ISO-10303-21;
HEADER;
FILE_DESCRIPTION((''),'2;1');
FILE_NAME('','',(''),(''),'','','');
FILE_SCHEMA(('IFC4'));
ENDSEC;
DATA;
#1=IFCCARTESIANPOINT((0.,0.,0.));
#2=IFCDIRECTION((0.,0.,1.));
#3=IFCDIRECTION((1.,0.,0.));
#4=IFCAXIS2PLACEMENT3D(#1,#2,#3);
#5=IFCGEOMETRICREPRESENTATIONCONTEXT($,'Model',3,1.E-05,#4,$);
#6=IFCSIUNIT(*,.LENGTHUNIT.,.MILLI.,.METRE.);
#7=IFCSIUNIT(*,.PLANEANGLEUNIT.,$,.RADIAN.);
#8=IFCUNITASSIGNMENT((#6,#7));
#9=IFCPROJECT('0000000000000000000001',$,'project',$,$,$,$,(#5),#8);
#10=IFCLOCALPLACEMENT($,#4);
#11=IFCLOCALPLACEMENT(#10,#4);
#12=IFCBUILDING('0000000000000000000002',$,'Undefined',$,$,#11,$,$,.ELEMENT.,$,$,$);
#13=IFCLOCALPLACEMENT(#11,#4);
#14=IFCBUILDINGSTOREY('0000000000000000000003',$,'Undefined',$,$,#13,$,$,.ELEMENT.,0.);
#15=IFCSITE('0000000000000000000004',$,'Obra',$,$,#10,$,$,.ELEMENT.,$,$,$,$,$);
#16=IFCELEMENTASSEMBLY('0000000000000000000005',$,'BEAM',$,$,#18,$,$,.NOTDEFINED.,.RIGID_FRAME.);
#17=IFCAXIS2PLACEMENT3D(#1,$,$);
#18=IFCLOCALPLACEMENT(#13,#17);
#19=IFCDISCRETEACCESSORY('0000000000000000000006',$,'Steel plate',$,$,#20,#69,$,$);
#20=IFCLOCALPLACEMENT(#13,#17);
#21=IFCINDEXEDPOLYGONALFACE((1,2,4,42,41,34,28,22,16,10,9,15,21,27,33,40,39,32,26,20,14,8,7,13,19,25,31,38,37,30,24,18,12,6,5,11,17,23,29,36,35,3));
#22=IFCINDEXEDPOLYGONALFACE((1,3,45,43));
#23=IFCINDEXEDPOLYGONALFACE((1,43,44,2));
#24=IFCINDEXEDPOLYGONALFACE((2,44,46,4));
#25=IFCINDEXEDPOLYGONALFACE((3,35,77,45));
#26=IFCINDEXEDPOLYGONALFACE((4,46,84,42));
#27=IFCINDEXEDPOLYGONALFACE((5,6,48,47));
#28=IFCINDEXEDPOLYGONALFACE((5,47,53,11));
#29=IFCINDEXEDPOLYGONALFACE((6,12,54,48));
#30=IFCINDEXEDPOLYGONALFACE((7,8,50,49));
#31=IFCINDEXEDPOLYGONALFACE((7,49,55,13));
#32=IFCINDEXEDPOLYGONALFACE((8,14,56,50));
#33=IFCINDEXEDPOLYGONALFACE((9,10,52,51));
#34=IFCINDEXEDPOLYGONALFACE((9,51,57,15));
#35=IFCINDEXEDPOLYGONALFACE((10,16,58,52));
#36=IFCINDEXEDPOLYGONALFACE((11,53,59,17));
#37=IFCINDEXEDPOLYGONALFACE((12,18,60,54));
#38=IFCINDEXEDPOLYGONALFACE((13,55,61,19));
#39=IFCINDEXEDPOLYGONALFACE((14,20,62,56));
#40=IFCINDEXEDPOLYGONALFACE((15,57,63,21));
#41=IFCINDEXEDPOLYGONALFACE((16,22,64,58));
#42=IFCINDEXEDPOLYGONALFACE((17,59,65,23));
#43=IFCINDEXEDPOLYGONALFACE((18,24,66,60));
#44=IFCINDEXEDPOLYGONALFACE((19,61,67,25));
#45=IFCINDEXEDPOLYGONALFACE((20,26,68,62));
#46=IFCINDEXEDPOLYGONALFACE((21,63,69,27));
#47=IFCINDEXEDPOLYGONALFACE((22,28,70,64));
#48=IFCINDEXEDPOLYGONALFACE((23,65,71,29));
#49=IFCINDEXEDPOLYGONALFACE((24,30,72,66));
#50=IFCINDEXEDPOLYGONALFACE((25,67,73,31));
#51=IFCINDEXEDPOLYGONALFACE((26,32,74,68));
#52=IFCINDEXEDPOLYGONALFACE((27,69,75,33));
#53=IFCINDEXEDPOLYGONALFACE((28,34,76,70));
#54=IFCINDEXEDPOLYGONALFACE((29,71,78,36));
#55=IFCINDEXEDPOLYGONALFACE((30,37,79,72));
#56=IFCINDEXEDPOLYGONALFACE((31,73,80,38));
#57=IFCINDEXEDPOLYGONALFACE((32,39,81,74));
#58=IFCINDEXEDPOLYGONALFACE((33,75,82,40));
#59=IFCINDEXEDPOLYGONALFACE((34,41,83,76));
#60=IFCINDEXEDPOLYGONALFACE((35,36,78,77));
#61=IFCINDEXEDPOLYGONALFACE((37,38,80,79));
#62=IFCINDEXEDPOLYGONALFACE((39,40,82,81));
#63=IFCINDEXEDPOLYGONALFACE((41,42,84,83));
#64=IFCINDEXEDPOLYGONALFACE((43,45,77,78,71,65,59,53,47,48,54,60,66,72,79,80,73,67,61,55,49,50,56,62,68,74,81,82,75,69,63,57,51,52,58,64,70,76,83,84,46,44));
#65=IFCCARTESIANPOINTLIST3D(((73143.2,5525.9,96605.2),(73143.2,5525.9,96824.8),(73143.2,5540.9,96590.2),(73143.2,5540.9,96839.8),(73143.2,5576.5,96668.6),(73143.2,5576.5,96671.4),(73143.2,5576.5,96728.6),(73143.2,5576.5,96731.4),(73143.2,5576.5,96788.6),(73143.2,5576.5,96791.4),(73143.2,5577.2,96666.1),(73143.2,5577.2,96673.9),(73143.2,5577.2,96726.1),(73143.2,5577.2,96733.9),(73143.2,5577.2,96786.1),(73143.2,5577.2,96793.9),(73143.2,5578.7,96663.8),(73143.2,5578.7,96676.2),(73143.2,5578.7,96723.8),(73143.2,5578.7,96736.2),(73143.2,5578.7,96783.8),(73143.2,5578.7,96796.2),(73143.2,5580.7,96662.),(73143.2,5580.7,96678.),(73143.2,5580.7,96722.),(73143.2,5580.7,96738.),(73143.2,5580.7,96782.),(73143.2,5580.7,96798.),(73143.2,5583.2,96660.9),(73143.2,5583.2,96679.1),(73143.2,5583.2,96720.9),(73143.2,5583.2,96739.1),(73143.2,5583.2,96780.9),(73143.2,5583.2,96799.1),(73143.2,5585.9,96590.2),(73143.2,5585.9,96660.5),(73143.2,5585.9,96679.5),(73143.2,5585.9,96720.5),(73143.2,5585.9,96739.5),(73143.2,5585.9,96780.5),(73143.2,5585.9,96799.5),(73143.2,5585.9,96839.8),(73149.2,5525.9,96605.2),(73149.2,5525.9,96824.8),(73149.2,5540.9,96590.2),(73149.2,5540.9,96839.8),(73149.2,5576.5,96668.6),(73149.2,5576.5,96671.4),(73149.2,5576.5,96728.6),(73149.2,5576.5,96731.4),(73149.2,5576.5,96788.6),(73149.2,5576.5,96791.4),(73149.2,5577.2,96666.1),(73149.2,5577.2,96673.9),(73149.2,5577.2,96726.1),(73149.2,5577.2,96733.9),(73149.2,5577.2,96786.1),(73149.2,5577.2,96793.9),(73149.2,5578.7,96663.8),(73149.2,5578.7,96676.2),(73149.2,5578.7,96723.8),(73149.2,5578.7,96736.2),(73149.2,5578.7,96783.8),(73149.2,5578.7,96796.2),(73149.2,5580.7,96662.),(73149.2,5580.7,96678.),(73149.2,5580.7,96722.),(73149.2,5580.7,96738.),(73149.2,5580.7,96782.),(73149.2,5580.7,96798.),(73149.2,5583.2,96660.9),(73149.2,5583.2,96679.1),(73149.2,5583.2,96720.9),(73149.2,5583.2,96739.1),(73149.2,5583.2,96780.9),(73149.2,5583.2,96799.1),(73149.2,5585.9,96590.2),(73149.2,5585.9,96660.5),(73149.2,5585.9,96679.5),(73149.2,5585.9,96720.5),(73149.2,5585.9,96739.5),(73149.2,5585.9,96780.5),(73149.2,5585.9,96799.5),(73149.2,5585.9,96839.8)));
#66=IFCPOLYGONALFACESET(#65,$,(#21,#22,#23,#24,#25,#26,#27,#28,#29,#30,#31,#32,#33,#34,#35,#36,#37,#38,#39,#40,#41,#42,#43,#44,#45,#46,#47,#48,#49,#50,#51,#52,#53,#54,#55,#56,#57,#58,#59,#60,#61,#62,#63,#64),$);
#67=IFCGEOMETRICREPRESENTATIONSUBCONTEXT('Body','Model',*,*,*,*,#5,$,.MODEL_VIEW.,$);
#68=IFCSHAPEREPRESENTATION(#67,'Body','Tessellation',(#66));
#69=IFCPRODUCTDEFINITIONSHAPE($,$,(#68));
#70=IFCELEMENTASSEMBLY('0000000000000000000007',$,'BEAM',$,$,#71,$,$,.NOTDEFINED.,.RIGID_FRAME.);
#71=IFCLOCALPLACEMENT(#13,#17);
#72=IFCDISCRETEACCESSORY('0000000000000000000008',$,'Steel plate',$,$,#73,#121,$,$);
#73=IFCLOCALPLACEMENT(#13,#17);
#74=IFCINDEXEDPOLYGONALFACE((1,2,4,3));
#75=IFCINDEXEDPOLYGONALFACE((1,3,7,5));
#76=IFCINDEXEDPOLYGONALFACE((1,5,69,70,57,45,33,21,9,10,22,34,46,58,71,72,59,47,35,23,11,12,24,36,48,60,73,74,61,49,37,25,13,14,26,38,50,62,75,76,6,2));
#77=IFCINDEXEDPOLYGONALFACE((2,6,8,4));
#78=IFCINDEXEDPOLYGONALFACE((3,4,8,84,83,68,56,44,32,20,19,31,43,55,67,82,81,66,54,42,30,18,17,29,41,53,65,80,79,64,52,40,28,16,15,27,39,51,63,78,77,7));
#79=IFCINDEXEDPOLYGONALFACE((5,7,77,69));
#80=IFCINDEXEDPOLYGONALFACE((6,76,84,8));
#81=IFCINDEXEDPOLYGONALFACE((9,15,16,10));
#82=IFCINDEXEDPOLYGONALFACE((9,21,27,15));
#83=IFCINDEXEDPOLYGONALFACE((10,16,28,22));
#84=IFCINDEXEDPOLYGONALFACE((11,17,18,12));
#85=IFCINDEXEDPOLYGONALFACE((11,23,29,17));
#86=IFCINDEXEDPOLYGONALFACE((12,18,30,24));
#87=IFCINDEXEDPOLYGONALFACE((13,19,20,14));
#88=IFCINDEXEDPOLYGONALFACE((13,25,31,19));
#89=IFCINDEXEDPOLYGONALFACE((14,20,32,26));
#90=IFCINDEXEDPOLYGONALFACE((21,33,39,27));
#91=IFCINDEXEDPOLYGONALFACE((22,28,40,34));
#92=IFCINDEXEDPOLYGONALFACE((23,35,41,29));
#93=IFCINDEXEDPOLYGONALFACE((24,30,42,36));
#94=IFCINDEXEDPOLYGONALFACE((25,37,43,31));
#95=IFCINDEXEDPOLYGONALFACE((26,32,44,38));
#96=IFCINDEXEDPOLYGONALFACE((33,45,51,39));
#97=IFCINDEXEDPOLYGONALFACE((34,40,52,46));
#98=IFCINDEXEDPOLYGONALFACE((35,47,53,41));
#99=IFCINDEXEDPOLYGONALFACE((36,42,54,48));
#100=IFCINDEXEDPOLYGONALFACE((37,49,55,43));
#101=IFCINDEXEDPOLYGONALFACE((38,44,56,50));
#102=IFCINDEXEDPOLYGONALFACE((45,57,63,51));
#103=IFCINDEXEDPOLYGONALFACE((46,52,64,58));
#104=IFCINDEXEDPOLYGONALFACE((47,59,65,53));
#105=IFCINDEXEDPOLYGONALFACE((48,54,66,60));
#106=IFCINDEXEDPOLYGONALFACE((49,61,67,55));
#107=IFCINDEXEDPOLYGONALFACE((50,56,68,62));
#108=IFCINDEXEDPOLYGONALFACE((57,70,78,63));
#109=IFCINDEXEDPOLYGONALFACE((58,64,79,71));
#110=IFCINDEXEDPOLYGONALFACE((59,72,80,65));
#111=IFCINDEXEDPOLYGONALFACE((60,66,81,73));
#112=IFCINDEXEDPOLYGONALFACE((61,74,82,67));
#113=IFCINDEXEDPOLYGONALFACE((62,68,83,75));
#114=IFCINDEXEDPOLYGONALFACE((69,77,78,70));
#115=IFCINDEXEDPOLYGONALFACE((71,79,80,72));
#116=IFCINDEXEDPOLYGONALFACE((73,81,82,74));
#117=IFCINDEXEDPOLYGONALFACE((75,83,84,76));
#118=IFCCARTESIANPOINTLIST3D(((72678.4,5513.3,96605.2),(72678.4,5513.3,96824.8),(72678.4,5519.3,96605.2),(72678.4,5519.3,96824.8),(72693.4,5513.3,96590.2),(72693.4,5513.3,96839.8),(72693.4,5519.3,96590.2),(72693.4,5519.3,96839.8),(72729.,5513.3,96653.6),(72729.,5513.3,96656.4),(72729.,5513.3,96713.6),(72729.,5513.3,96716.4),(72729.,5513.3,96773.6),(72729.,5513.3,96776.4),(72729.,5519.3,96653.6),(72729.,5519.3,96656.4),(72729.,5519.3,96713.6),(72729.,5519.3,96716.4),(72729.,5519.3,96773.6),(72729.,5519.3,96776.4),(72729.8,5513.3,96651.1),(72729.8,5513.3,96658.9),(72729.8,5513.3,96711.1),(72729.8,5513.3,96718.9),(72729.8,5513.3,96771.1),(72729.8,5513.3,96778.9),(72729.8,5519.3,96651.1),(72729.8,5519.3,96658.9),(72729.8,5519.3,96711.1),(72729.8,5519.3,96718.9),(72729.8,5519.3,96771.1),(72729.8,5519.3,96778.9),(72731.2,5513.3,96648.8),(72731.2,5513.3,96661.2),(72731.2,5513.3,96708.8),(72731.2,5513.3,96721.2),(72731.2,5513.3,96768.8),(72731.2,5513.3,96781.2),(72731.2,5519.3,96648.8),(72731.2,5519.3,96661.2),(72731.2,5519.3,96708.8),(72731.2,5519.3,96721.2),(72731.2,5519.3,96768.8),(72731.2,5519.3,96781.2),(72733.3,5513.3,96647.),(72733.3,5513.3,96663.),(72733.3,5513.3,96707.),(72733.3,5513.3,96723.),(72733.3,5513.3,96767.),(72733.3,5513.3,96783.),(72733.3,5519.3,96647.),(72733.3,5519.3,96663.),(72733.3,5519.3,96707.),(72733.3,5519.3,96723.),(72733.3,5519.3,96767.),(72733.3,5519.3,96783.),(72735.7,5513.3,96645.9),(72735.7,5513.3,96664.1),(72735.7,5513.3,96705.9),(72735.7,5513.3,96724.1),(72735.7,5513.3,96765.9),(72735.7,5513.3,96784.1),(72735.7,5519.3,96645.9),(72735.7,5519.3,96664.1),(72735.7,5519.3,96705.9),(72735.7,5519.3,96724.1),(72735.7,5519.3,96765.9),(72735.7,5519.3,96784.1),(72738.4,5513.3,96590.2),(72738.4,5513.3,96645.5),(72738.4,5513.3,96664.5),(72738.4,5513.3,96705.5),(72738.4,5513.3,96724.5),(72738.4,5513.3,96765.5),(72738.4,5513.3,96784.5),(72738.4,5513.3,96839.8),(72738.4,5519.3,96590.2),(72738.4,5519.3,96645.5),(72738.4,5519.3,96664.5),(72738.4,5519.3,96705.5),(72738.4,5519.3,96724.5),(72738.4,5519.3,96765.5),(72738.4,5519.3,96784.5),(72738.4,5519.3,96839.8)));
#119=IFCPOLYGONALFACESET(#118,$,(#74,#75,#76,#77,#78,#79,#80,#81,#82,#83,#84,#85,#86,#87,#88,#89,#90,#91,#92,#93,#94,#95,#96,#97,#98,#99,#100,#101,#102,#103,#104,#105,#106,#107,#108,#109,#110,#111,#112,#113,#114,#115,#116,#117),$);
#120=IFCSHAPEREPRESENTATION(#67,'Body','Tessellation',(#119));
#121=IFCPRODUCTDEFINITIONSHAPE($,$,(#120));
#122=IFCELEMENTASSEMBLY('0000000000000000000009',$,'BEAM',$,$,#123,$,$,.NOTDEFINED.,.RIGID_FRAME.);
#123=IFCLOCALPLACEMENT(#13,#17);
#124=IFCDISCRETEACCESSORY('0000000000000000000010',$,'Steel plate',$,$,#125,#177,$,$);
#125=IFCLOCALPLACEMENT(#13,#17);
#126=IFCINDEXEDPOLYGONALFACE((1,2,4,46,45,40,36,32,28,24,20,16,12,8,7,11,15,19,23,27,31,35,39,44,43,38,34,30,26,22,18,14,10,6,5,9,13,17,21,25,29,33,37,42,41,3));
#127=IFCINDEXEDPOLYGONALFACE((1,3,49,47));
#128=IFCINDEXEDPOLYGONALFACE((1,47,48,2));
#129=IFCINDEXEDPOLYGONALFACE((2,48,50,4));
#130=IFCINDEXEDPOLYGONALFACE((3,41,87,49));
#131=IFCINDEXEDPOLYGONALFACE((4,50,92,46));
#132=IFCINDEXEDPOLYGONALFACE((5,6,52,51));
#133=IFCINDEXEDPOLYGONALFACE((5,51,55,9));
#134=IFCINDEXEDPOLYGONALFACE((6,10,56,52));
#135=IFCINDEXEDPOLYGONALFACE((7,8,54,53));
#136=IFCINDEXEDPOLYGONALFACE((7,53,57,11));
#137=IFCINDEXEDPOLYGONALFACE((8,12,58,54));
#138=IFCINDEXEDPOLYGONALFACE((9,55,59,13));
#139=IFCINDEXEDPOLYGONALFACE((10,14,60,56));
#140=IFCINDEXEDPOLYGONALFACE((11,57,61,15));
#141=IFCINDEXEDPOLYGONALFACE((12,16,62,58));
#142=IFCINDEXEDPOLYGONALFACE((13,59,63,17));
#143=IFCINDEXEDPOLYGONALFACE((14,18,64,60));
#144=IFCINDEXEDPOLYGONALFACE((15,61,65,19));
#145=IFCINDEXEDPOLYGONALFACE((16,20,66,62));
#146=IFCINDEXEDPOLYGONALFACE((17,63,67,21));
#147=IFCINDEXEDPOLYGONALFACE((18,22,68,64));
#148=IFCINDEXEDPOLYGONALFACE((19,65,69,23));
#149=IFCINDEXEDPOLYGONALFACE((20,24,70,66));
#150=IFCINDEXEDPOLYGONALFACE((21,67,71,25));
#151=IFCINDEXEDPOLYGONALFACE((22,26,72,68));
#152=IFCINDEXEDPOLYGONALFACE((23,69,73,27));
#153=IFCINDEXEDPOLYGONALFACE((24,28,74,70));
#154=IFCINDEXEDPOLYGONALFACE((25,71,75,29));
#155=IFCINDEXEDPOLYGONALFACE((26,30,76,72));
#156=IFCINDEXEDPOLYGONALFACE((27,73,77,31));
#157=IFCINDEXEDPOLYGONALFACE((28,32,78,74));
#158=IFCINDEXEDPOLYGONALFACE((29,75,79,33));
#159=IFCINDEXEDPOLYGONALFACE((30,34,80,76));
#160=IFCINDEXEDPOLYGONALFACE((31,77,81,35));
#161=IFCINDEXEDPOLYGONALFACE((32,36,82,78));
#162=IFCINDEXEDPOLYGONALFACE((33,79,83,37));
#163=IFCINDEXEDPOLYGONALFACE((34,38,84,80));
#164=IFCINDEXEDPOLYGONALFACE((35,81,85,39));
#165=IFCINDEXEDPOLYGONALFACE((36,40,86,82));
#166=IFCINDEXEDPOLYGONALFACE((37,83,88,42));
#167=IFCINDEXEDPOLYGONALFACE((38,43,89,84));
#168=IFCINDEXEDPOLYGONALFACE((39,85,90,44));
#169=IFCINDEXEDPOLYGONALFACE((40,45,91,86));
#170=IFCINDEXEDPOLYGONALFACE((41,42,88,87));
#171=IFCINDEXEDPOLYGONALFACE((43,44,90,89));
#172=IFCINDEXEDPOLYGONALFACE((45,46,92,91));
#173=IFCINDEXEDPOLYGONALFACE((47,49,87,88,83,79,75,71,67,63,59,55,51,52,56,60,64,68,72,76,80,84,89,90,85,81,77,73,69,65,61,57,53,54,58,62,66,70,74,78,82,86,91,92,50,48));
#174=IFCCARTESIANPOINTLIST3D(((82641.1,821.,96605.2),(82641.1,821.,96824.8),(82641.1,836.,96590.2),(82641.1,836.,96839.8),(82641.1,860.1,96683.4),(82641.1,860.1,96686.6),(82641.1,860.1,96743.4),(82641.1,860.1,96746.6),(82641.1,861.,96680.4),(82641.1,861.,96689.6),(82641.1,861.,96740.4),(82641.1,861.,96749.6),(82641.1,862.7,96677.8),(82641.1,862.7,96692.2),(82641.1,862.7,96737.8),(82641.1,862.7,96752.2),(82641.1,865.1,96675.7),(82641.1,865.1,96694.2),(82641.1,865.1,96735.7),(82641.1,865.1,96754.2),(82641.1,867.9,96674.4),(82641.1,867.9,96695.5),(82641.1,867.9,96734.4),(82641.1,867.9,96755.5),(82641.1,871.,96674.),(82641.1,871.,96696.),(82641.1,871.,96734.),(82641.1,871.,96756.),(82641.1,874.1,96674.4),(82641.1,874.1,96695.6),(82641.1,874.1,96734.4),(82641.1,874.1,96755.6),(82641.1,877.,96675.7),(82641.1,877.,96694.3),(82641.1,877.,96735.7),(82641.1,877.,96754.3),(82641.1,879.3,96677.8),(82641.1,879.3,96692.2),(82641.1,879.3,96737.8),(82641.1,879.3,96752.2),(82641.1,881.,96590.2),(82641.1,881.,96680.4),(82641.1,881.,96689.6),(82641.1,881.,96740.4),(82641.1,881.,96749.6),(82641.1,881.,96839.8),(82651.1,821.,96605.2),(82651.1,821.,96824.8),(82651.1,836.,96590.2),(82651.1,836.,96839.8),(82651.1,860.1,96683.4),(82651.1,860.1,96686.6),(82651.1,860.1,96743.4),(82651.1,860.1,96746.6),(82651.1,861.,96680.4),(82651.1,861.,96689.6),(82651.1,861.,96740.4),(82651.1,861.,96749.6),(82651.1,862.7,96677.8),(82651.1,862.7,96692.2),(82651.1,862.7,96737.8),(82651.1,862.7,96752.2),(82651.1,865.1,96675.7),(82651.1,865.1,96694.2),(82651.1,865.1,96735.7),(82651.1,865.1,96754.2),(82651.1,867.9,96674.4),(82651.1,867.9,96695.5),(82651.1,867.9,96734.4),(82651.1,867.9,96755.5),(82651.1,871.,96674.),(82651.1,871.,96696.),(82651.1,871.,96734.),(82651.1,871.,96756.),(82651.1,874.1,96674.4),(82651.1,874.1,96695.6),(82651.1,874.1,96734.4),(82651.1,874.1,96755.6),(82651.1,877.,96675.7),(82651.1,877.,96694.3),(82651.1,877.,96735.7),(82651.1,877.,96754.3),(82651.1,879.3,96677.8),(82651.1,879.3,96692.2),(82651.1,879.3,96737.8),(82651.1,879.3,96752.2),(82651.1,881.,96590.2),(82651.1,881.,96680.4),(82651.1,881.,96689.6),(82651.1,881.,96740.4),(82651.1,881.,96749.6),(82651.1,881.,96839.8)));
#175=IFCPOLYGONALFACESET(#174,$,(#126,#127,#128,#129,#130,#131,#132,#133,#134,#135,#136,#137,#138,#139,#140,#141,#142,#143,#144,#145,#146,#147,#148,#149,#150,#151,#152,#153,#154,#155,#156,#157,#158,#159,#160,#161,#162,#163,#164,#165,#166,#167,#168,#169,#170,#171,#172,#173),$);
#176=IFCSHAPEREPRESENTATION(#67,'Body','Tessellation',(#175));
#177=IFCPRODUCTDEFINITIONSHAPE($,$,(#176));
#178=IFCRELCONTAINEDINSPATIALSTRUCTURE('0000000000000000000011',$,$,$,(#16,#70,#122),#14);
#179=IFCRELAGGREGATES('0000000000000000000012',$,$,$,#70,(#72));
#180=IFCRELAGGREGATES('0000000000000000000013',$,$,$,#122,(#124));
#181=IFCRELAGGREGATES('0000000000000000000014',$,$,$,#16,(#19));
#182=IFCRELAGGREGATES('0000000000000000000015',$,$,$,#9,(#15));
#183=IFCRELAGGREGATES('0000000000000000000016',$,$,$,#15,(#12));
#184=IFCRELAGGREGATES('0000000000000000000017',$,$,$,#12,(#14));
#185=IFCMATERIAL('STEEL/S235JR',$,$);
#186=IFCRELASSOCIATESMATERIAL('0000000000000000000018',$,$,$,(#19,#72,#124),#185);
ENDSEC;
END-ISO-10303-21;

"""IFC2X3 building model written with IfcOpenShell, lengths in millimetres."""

from ifc_helpers import new_model, si_unit, frame, origin_with_axes, origin_2d_with_axis, place, context, subcontext, project, spatial, polyline, circle, outline, extrude, source, transform, mapped, material, element, aggregate, save


model = new_model("IFC2X3")

# Units and contexts
model_context = context("Model", 3, precision=1e-05, world=origin_with_axes())
body_context = subcontext(model_context, "Body", "Model", "MODEL_VIEW")
ifc_project = project(units=[si_unit("LENGTHUNIT", "METRE", prefix="MILLI"), si_unit("PLANEANGLEUNIT", "RADIAN")], contexts=[model_context])

# Site, building, storey
site_placement = place(None, origin_with_axes())
site = spatial("IfcSite", under=ifc_project, at=site_placement, Name="Obra", CompositionType="ELEMENT")
building_placement = place(site_placement, origin_with_axes())
building = spatial("IfcBuilding", under=site, at=building_placement, Name="Undefined", CompositionType="ELEMENT")
storey_placement = place(building_placement, origin_with_axes())
storey = spatial("IfcBuildingStorey", under=building, at=storey_placement, Name="Undefined", CompositionType="ELEMENT", Elevation=0.0)

# Shared definitions
ifc_material = material(Name="STEEL/S235JR")

# Element assemblies, discrete accessories, openings
assembly_1_placement = place(storey_placement, origin_with_axes())
assembly_1 = element("IfcElementAssembly", 1, at=assembly_1_placement, inside=storey, Name="BEAM", AssemblyPlace="NOTDEFINED", PredefinedType="RIGID_FRAME")
discrete_accessory_1_placement = place(assembly_1_placement, frame((73146.2, 5585.9, 96590.2), z_axis=(-1.0, 0.0, 0.0), x_axis=(0.0, -1.0, 0.0)))
discrete_accessory_1 = element("IfcDiscreteAccessory", 2, at=discrete_accessory_1_placement, material=ifc_material, Name="Steel plate", context=body_context, shape_type="SweptSolid", body=[
    extrude(outline(polyline([(0.0, 0.0), (45.0, 0.0), (60.0, 15.0), (60.0, 234.6), (45.0, 249.6), (0.0, 249.6), (0.0, 0.0)])), frame((0.0, 0.0, -3.0), z_axis=(0.0, 0.0, 1.0), x_axis=(1.0, 0.0, 0.0)), (0.0, 0.0, 1.0), 6.0),
])
shared_shape_1 = source(origin_with_axes(), body_context, "Body", "SweptSolid", [
    extrude(circle(Radius=9.5, at=origin_2d_with_axis()), frame((0.0, -9.2, 0.0), z_axis=(0.0, 1.0, 0.0), x_axis=(1.0, 0.0, 0.0)), (0.0, 0.0, 1.0), 6.2),
])
opening_1_placement = place(assembly_1_placement, frame((73140.1, 5535.9, 96850.0), z_axis=(0.0, 1.0, 0.0), x_axis=(0.0, 0.0, -1.0)))
element("IfcOpeningElement", 3, at=opening_1_placement, cuts=discrete_accessory_1, ObjectType="Opening", context=body_context, shape_type="MappedRepresentation", body=[
    mapped(shared_shape_1, transform((60.0, 0.0, 50.0))),
    mapped(shared_shape_1, transform((120.0, 0.0, 50.0))),
    mapped(shared_shape_1, transform((180.0, 0.0, 50.0))),
])
assembly_2_placement = place(storey_placement, origin_with_axes())
assembly_2 = element("IfcElementAssembly", 4, at=assembly_2_placement, inside=storey, Name="BEAM", AssemblyPlace="NOTDEFINED", PredefinedType="RIGID_FRAME")
discrete_accessory_2_placement = place(assembly_2_placement, frame((72738.4, 5516.3, 96590.2), z_axis=(0.0, 1.0, 0.0), x_axis=(-1.0, 0.0, 0.0)))
discrete_accessory_2 = element("IfcDiscreteAccessory", 5, at=discrete_accessory_2_placement, material=ifc_material, Name="Steel plate", context=body_context, shape_type="SweptSolid", body=[
    extrude(outline(polyline([(0.0, 0.0), (45.0, 0.0), (60.0, 15.0), (60.0, 234.6), (45.0, 249.6), (0.0, 249.6), (0.0, 0.0)])), frame((0.0, 0.0, -3.0), z_axis=(0.0, 0.0, 1.0), x_axis=(1.0, 0.0, 0.0)), (0.0, 0.0, 1.0), 6.0),
])
shared_shape_2 = source(origin_with_axes(), body_context, "Body", "SweptSolid", [
    extrude(circle(Radius=9.5, at=origin_2d_with_axis()), frame((0.0, -9.4, 0.0), z_axis=(0.0, 1.0, 0.0), x_axis=(1.0, 0.0, 0.0)), (0.0, 0.0, 1.0), 6.2),
])
opening_2_placement = place(assembly_2_placement, frame((72688.4, 5522.6, 96850.0), z_axis=(1.0, 0.0, 0.0), x_axis=(0.0, 0.0, -1.0)))
element("IfcOpeningElement", 6, at=opening_2_placement, cuts=discrete_accessory_2, ObjectType="Opening", context=body_context, shape_type="MappedRepresentation", body=[
    mapped(shared_shape_2, transform((75.0, 0.0, 50.0))),
    mapped(shared_shape_2, transform((135.0, 0.0, 50.0))),
    mapped(shared_shape_2, transform((195.0, 0.0, 50.0))),
])
aggregate(assembly_2, [discrete_accessory_2])

# Element assembly, discrete accessory, opening
assembly_3_placement = place(storey_placement, origin_with_axes())
assembly_3 = element("IfcElementAssembly", 7, at=assembly_3_placement, inside=storey, Name="BEAM", AssemblyPlace="NOTDEFINED", PredefinedType="RIGID_FRAME")
discrete_accessory_3_placement = place(assembly_3_placement, frame((82646.1, 881.0, 96590.2), z_axis=(-1.0, 0.0, 0.0), x_axis=(0.0, -1.0, 0.0)))
discrete_accessory_3 = element("IfcDiscreteAccessory", 8, at=discrete_accessory_3_placement, material=ifc_material, Name="Steel plate", context=body_context, shape_type="SweptSolid", body=[
    extrude(outline(polyline([(0.0, 0.0), (45.0, 0.0), (60.0, 15.0), (60.0, 234.6), (45.0, 249.6), (0.0, 249.6), (0.0, 0.0)])), frame((0.0, 0.0, -5.0), z_axis=(0.0, 0.0, 1.0), x_axis=(1.0, 0.0, 0.0)), (0.0, 0.0, 1.0), 10.0),
])
shared_shape_3 = source(origin_with_axes(), body_context, "Body", "SweptSolid", [
    extrude(circle(Radius=11.0, at=origin_2d_with_axis()), frame((0.0, -13.4, 0.0), z_axis=(0.0, 1.0, 0.0), x_axis=(1.0, 0.0, 0.0)), (0.0, 0.0, 1.0), 10.2),
])
opening_3_placement = place(assembly_3_placement, frame((82637.8, 831.0, 96850.0), z_axis=(0.0, 1.0, 0.0), x_axis=(0.0, 0.0, -1.0)))
element("IfcOpeningElement", 9, at=opening_3_placement, cuts=discrete_accessory_3, ObjectType="Opening", context=body_context, shape_type="MappedRepresentation", body=[
    mapped(shared_shape_3, transform((105.0, 0.0, 40.0))),
    mapped(shared_shape_3, transform((165.0, 0.0, 40.0))),
])
aggregate(assembly_3, [discrete_accessory_3])

aggregate(assembly_1, [discrete_accessory_1])

save(model, "model.ifc")
